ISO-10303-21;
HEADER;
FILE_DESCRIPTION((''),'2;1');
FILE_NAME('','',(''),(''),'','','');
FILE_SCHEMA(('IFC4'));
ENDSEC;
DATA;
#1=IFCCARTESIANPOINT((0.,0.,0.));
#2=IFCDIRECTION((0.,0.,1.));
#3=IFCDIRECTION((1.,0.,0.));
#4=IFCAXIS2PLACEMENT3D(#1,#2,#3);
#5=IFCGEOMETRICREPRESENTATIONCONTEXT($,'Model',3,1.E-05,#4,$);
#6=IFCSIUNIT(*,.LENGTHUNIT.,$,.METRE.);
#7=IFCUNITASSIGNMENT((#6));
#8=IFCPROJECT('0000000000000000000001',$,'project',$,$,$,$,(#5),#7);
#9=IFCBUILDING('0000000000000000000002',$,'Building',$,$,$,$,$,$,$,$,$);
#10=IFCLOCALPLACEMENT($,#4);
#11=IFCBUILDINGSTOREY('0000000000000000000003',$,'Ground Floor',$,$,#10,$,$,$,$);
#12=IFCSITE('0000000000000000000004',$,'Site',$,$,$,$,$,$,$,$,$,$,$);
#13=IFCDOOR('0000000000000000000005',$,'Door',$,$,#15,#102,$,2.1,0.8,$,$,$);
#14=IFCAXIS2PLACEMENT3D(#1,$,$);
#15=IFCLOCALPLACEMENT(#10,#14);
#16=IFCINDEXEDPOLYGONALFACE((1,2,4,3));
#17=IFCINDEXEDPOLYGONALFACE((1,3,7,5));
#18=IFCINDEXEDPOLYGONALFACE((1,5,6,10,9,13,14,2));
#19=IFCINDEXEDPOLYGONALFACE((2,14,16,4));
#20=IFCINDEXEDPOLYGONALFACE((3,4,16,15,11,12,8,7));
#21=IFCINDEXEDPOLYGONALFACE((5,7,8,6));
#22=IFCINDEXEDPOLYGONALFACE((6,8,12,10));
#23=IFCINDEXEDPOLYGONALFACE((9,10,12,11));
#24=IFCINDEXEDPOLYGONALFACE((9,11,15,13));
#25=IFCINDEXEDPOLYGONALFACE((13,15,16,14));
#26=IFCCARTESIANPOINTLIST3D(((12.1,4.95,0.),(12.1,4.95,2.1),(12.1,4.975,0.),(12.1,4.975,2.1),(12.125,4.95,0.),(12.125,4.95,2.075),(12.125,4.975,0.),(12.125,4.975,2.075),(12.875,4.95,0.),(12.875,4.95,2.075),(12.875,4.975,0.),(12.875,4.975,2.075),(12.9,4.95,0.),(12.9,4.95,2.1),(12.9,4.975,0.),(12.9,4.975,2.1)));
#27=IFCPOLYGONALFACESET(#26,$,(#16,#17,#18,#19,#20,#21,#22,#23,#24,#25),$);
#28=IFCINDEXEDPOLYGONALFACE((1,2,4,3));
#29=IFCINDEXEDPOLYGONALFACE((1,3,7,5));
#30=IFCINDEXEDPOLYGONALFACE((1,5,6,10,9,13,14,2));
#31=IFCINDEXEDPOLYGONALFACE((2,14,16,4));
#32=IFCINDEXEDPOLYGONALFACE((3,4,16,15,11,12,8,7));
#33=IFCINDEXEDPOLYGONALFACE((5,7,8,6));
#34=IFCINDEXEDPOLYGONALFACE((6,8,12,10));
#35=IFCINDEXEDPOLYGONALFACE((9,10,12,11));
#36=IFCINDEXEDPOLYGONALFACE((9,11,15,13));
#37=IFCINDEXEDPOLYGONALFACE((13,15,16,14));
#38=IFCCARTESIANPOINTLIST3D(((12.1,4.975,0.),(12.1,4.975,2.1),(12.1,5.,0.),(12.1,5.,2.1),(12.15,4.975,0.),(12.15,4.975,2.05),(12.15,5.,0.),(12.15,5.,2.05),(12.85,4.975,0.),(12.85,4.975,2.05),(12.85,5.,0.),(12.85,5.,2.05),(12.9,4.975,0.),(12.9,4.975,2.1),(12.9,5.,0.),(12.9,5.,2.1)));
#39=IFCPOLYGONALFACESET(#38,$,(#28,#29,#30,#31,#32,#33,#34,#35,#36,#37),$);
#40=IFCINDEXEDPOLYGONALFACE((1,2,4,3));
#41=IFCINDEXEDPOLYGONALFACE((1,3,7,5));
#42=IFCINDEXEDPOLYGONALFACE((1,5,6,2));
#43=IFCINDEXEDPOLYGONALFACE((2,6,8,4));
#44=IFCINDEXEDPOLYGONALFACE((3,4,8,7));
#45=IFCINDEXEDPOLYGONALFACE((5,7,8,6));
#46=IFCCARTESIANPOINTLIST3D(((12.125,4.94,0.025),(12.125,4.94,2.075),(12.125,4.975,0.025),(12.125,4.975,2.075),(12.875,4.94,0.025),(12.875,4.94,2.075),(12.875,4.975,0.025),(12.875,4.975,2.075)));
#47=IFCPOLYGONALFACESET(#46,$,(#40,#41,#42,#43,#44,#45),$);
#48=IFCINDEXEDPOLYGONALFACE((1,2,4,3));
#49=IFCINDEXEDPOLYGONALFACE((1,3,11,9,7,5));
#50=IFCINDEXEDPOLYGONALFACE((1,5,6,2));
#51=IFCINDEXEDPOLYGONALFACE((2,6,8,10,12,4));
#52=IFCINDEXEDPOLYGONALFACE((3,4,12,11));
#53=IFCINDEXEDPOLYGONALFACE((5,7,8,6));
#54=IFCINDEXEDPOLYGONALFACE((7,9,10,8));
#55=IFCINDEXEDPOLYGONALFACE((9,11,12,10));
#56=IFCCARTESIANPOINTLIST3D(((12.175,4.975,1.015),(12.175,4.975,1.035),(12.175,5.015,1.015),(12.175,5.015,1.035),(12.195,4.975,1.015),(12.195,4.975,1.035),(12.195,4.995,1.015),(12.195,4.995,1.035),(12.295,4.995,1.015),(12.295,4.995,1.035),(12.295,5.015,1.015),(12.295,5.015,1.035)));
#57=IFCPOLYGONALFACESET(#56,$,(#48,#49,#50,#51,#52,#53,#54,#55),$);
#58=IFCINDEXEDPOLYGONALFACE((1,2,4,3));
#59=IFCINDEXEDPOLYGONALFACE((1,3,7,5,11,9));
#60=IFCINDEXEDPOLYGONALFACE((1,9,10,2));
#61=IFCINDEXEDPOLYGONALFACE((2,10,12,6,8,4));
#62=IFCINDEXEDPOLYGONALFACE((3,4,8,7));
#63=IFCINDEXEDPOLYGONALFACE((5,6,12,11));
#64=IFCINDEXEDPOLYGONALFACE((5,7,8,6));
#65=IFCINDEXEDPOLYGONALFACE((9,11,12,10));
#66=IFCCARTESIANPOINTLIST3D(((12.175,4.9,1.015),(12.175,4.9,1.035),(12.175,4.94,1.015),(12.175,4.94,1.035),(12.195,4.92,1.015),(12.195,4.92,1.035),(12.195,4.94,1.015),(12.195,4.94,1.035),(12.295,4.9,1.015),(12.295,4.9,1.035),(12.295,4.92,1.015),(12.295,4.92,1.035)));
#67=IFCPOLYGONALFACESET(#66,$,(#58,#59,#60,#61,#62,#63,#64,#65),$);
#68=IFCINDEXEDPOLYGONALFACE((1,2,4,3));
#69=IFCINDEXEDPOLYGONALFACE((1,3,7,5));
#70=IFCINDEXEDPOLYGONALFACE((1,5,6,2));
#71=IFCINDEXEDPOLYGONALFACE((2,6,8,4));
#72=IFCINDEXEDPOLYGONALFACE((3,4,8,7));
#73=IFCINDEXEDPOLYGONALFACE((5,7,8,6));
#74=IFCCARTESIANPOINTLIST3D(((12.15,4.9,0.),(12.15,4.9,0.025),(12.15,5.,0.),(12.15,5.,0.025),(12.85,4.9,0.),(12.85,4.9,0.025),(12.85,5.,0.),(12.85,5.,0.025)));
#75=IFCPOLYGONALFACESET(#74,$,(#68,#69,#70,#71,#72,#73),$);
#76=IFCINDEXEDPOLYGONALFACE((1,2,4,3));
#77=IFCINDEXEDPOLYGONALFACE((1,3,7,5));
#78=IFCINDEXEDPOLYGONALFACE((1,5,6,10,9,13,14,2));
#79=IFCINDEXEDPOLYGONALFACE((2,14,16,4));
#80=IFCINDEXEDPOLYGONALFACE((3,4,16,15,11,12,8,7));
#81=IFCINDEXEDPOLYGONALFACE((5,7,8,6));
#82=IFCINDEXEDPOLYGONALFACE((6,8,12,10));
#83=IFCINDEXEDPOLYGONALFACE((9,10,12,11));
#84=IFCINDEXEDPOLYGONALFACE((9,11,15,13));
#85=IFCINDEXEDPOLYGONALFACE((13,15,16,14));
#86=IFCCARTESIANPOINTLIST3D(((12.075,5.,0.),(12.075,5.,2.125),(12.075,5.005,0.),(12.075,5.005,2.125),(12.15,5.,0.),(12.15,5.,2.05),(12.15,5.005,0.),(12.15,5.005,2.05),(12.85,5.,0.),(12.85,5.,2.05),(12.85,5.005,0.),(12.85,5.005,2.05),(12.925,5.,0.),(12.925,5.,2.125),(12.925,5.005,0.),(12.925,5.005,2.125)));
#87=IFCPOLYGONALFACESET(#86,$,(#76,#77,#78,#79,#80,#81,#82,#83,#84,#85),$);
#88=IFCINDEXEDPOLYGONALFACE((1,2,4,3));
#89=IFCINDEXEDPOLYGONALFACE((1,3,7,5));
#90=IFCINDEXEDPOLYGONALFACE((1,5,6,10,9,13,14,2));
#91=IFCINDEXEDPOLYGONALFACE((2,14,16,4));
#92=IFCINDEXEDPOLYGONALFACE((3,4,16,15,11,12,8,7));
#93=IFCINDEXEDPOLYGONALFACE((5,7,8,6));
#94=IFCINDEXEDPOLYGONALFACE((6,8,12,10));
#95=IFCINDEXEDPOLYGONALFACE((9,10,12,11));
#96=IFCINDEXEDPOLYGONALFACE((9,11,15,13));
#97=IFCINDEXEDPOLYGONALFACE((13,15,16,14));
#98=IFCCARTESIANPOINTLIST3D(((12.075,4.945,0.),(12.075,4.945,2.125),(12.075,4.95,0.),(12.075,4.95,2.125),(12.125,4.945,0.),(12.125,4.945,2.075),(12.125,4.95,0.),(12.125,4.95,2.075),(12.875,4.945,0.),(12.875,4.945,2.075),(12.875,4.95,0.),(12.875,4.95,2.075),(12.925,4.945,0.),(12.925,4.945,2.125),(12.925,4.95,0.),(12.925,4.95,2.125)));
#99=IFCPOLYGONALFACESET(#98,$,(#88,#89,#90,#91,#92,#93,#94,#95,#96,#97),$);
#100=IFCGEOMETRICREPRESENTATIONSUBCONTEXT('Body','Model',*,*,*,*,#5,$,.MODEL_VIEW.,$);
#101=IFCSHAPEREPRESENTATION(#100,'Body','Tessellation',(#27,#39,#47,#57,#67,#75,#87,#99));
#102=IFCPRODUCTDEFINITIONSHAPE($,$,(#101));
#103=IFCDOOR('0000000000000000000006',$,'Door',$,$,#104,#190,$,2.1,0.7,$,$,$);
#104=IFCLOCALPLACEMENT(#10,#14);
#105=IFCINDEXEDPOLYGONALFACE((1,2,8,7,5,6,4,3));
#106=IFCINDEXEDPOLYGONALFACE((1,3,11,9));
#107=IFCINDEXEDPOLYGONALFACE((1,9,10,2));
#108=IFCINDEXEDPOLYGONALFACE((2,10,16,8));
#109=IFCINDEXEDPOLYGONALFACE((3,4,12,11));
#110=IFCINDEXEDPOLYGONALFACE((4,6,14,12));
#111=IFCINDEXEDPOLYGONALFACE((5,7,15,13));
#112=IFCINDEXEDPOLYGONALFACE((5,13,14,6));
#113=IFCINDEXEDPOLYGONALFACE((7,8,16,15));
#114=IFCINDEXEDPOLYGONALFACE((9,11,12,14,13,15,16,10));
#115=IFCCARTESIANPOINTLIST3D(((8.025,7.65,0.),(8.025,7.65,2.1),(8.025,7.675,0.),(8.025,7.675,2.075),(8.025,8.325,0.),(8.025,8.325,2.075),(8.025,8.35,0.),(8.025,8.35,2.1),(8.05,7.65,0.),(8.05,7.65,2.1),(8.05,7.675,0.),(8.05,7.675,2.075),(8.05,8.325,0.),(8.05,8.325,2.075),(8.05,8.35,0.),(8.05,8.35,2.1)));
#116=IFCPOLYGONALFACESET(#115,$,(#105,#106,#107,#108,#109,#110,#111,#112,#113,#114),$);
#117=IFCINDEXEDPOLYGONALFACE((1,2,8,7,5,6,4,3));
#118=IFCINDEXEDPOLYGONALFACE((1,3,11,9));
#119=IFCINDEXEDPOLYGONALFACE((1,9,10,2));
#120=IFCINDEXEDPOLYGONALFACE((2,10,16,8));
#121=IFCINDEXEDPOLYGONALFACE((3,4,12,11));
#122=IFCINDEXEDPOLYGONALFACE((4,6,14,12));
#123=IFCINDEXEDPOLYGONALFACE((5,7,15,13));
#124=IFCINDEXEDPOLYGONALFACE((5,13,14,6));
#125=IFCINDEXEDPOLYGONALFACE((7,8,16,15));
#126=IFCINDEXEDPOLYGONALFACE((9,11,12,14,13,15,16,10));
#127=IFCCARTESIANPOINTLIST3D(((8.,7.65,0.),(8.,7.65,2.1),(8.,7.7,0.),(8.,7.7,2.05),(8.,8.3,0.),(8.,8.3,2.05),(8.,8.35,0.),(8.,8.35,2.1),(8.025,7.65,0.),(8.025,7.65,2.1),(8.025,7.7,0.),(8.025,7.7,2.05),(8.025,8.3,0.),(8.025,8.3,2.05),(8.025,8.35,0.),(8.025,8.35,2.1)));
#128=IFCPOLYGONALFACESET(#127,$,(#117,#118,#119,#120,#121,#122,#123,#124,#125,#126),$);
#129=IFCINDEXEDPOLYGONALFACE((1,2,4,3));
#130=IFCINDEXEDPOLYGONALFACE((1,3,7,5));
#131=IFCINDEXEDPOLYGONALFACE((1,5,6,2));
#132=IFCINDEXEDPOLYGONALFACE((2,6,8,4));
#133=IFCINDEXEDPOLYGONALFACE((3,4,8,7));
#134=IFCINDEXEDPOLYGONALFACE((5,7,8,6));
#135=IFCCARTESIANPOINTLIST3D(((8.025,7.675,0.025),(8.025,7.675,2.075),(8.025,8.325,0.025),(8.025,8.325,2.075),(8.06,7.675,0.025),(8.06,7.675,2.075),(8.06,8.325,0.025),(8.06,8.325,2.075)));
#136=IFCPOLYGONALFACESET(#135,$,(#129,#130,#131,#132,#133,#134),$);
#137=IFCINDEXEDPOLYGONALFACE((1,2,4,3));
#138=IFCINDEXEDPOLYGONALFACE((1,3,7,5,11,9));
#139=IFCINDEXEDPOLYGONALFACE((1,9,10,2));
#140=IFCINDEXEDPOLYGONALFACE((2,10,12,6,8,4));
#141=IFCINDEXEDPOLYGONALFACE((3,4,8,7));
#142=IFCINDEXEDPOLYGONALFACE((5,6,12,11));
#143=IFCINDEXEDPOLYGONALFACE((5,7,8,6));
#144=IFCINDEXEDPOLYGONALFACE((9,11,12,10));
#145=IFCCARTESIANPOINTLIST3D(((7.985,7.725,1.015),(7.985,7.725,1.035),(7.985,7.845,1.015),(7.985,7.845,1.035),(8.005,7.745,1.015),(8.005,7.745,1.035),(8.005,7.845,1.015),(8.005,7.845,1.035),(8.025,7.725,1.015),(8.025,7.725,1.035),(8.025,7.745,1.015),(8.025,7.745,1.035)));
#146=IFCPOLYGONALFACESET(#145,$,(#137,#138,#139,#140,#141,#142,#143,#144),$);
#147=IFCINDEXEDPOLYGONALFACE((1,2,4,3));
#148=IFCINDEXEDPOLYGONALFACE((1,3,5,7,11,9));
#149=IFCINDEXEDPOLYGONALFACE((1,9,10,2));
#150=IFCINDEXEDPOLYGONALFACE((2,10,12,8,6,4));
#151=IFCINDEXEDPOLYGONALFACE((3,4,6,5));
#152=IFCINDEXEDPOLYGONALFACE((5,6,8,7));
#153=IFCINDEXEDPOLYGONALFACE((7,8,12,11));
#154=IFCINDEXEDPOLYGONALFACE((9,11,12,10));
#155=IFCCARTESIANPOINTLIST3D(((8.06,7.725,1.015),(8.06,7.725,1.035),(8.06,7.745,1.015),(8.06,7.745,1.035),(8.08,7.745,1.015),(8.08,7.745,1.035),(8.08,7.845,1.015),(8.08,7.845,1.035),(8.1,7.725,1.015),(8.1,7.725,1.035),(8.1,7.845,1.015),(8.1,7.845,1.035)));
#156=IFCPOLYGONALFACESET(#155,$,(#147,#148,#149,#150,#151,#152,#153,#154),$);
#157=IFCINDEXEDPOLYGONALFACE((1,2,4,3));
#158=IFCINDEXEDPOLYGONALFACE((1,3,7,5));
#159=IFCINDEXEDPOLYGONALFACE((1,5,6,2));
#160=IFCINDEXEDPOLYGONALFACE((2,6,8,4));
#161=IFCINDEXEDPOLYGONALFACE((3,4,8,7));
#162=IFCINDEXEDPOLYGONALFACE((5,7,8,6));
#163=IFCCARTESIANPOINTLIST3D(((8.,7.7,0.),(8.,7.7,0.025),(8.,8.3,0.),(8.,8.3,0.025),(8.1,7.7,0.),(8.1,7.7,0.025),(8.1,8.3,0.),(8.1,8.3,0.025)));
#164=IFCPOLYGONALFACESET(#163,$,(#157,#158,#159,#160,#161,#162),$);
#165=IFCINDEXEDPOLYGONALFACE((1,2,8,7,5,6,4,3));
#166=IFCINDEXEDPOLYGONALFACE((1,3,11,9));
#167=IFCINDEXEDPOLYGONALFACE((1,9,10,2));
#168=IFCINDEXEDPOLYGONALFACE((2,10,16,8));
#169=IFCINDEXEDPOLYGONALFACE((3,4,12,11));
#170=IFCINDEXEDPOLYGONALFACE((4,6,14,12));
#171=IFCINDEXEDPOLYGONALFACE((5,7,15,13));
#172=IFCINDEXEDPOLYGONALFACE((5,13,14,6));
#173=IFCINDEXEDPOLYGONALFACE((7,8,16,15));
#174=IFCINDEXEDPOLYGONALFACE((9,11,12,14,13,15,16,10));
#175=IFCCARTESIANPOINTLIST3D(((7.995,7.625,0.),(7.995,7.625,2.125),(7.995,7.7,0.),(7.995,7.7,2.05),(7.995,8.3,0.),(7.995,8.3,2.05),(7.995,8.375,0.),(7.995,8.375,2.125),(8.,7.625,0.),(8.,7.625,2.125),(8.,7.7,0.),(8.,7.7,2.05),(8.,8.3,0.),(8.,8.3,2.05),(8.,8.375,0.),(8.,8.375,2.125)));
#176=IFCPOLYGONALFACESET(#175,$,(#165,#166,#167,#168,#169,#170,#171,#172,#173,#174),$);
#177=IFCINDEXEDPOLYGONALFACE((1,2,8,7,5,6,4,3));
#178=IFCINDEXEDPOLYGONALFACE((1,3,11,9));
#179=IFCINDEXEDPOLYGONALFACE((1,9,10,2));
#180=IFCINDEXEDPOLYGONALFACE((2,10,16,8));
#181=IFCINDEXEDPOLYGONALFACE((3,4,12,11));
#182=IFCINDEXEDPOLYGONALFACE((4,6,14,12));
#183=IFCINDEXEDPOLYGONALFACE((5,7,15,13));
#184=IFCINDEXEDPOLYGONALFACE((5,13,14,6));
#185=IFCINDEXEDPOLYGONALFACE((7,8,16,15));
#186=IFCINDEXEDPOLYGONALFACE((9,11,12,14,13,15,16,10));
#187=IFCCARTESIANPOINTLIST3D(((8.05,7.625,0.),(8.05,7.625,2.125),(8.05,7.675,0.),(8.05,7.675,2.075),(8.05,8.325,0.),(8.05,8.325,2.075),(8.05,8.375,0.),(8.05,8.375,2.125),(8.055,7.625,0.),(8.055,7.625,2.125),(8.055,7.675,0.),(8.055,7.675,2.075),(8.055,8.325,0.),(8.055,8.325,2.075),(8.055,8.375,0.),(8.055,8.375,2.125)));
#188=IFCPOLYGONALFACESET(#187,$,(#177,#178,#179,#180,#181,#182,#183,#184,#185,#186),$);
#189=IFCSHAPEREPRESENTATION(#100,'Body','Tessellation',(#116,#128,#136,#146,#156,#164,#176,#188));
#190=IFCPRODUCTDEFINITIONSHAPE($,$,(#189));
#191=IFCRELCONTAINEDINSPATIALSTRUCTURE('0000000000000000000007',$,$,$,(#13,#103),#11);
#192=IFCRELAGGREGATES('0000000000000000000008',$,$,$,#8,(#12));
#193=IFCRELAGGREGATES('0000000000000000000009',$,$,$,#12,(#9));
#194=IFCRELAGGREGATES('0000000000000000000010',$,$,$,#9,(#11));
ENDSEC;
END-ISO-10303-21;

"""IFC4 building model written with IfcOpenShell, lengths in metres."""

from ifc_helpers import new_model, si_unit, frame, origin_with_axes, place, context, subcontext, project, spatial, line, indexed_curve, outline, extrude, element, save


model = new_model("IFC4")

# Units and contexts
model_context = context("Model", 3, precision=1e-05, world=origin_with_axes())
body_context = subcontext(model_context, "Body", "Model", "MODEL_VIEW")
ifc_project = project(units=[si_unit("LENGTHUNIT", "METRE")], contexts=[model_context])

# Site, building, storey
site = spatial("IfcSite", under=ifc_project, Name="Site")
building = spatial("IfcBuilding", under=site, Name="Building")
storey_placement = place(None, origin_with_axes())
storey = spatial("IfcBuildingStorey", under=building, at=storey_placement, Name="Ground Floor")

# Doors
door_1_placement = place(storey_placement, frame((12.9, 5.0, 0.0), z_axis=(0.0, 0.0, 1.0), x_axis=(-1.0, 0.0, 0.0)))
element("IfcDoor", 1, at=door_1_placement, inside=storey, Name="Door", OverallHeight=2.1, OverallWidth=0.8, context=body_context, shape_type="SweptSolid", body=[
    extrude(outline(indexed_curve([(0.0, 0.0), (0.0, 2.1), (0.8, 2.1), (0.8, 0.0), (0.775, 0.0), (0.775, 2.075), (0.025, 2.075), (0.025, 0.0)], segments=[line(1, 2, 3, 4, 5, 6, 7, 8, 1)])), frame((0.0, 0.025, 0.0), z_axis=(0.0, -1.0, 0.0), x_axis=(1.0, 0.0, 0.0)), (0.0, 0.0, -1.0), 0.025),
    extrude(outline(indexed_curve([(0.0, 0.0), (0.0, 2.1), (0.8, 2.1), (0.8, 0.0), (0.75, 0.0), (0.75, 2.05), (0.05, 2.05), (0.05, 0.0)], segments=[line(1, 2, 3, 4, 5, 6, 7, 8, 1)])), frame((0.0, 0.0, 0.0), z_axis=(0.0, -1.0, 0.0), x_axis=(1.0, 0.0, 0.0)), (0.0, 0.0, -1.0), 0.025),
    extrude(outline(indexed_curve([(0.0, 0.0), (0.75, 0.0), (0.75, 0.035), (0.0, 0.035)], segments=[line(1, 2, 3, 4, 1)])), frame((0.025, 0.025, 0.025), z_axis=(0.0, 0.0, 1.0), x_axis=(1.0, 0.0, 0.0)), (0.0, 0.0, 1.0), 2.05),
    extrude(outline(indexed_curve([(0.0, 0.0), (0.0, -0.04), (-0.12, -0.04), (-0.12, -0.02), (-0.02, -0.02), (-0.02, 0.0)], segments=[line(1, 2, 3, 4, 5, 6, 1)])), frame((0.725, 0.025, 1.015), z_axis=(0.0, 0.0, 1.0), x_axis=(1.0, 0.0, 0.0)), (0.0, 0.0, 1.0), 0.02),
    extrude(outline(indexed_curve([(0.0, 0.0), (0.0, 0.04), (-0.12, 0.04), (-0.12, 0.02), (-0.02, 0.02), (-0.02, 0.0)], segments=[line(1, 2, 3, 4, 5, 6, 1)])), frame((0.725, 0.06, 1.015), z_axis=(0.0, 0.0, 1.0), x_axis=(1.0, 0.0, 0.0)), (0.0, 0.0, 1.0), 0.02),
    extrude(outline(indexed_curve([(0.0, 0.0), (0.7, 0.0), (0.7, 0.1), (0.0, 0.1)], segments=[line(1, 2, 3, 4, 1)])), frame((0.05, 0.0, 0.0), z_axis=(0.0, 0.0, 1.0), x_axis=(1.0, 0.0, 0.0)), (0.0, 0.0, 1.0), 0.025),
    extrude(outline(indexed_curve([(0.0, 0.0), (0.0, 2.125), (0.85, 2.125), (0.85, 0.0), (0.775, 0.0), (0.775, 2.05), (0.075, 2.05), (0.075, 0.0)], segments=[line(1, 2, 3, 4, 5, 6, 7, 8, 1)])), frame((-0.025, -0.005, 0.0), z_axis=(0.0, -1.0, 0.0), x_axis=(1.0, 0.0, 0.0)), (0.0, 0.0, -1.0), 0.005),
    extrude(outline(indexed_curve([(0.0, 0.0), (0.0, 2.125), (0.85, 2.125), (0.85, 0.0), (0.8, 0.0), (0.8, 2.075), (0.05, 2.075), (0.05, 0.0)], segments=[line(1, 2, 3, 4, 5, 6, 7, 8, 1)])), frame((-0.025, 0.05, 0.0), z_axis=(0.0, -1.0, 0.0), x_axis=(1.0, 0.0, 0.0)), (0.0, 0.0, -1.0), 0.005),
])
door_2_placement = place(storey_placement, frame((8.0, 8.35, 0.0), z_axis=(0.0, 0.0, 1.0), x_axis=(0.0, -1.0, 0.0)))
element("IfcDoor", 2, at=door_2_placement, inside=storey, Name="Door", OverallHeight=2.1, OverallWidth=0.7, context=body_context, shape_type="SweptSolid", body=[
    extrude(outline(indexed_curve([(0.0, 0.0), (0.0, 2.1), (0.7, 2.1), (0.7, 0.0), (0.675, 0.0), (0.675, 2.075), (0.025, 2.075), (0.025, 0.0)], segments=[line(1, 2, 3, 4, 5, 6, 7, 8, 1)])), frame((0.0, 0.025, 0.0), z_axis=(0.0, -1.0, 0.0), x_axis=(1.0, 0.0, 0.0)), (0.0, 0.0, -1.0), 0.025),
    extrude(outline(indexed_curve([(0.0, 0.0), (0.0, 2.1), (0.7, 2.1), (0.7, 0.0), (0.65, 0.0), (0.65, 2.05), (0.05, 2.05), (0.05, 0.0)], segments=[line(1, 2, 3, 4, 5, 6, 7, 8, 1)])), frame((0.0, 0.0, 0.0), z_axis=(0.0, -1.0, 0.0), x_axis=(1.0, 0.0, 0.0)), (0.0, 0.0, -1.0), 0.025),
    extrude(outline(indexed_curve([(0.0, 0.0), (0.65, 0.0), (0.65, 0.035), (0.0, 0.035)], segments=[line(1, 2, 3, 4, 1)])), frame((0.025, 0.025, 0.025), z_axis=(0.0, 0.0, 1.0), x_axis=(1.0, 0.0, 0.0)), (0.0, 0.0, 1.0), 2.05),
    extrude(outline(indexed_curve([(0.0, 0.0), (0.0, -0.04), (-0.12, -0.04), (-0.12, -0.02), (-0.02, -0.02), (-0.02, 0.0)], segments=[line(1, 2, 3, 4, 5, 6, 1)])), frame((0.625, 0.025, 1.015), z_axis=(0.0, 0.0, 1.0), x_axis=(1.0, 0.0, 0.0)), (0.0, 0.0, 1.0), 0.02),
    extrude(outline(indexed_curve([(0.0, 0.0), (0.0, 0.04), (-0.12, 0.04), (-0.12, 0.02), (-0.02, 0.02), (-0.02, 0.0)], segments=[line(1, 2, 3, 4, 5, 6, 1)])), frame((0.625, 0.06, 1.015), z_axis=(0.0, 0.0, 1.0), x_axis=(1.0, 0.0, 0.0)), (0.0, 0.0, 1.0), 0.02),
    extrude(outline(indexed_curve([(0.0, 0.0), (0.6, 0.0), (0.6, 0.1), (0.0, 0.1)], segments=[line(1, 2, 3, 4, 1)])), frame((0.05, 0.0, 0.0), z_axis=(0.0, 0.0, 1.0), x_axis=(1.0, 0.0, 0.0)), (0.0, 0.0, 1.0), 0.025),
    extrude(outline(indexed_curve([(0.0, 0.0), (0.0, 2.125), (0.75, 2.125), (0.75, 0.0), (0.675, 0.0), (0.675, 2.05), (0.075, 2.05), (0.075, 0.0)], segments=[line(1, 2, 3, 4, 5, 6, 7, 8, 1)])), frame((-0.025, -0.005, 0.0), z_axis=(0.0, -1.0, 0.0), x_axis=(1.0, 0.0, 0.0)), (0.0, 0.0, -1.0), 0.005),
    extrude(outline(indexed_curve([(0.0, 0.0), (0.0, 2.125), (0.75, 2.125), (0.75, 0.0), (0.7, 0.0), (0.7, 2.075), (0.05, 2.075), (0.05, 0.0)], segments=[line(1, 2, 3, 4, 5, 6, 7, 8, 1)])), frame((-0.025, 0.05, 0.0), z_axis=(0.0, -1.0, 0.0), x_axis=(1.0, 0.0, 0.0)), (0.0, 0.0, -1.0), 0.005),
])

save(model, "model.ifc")
